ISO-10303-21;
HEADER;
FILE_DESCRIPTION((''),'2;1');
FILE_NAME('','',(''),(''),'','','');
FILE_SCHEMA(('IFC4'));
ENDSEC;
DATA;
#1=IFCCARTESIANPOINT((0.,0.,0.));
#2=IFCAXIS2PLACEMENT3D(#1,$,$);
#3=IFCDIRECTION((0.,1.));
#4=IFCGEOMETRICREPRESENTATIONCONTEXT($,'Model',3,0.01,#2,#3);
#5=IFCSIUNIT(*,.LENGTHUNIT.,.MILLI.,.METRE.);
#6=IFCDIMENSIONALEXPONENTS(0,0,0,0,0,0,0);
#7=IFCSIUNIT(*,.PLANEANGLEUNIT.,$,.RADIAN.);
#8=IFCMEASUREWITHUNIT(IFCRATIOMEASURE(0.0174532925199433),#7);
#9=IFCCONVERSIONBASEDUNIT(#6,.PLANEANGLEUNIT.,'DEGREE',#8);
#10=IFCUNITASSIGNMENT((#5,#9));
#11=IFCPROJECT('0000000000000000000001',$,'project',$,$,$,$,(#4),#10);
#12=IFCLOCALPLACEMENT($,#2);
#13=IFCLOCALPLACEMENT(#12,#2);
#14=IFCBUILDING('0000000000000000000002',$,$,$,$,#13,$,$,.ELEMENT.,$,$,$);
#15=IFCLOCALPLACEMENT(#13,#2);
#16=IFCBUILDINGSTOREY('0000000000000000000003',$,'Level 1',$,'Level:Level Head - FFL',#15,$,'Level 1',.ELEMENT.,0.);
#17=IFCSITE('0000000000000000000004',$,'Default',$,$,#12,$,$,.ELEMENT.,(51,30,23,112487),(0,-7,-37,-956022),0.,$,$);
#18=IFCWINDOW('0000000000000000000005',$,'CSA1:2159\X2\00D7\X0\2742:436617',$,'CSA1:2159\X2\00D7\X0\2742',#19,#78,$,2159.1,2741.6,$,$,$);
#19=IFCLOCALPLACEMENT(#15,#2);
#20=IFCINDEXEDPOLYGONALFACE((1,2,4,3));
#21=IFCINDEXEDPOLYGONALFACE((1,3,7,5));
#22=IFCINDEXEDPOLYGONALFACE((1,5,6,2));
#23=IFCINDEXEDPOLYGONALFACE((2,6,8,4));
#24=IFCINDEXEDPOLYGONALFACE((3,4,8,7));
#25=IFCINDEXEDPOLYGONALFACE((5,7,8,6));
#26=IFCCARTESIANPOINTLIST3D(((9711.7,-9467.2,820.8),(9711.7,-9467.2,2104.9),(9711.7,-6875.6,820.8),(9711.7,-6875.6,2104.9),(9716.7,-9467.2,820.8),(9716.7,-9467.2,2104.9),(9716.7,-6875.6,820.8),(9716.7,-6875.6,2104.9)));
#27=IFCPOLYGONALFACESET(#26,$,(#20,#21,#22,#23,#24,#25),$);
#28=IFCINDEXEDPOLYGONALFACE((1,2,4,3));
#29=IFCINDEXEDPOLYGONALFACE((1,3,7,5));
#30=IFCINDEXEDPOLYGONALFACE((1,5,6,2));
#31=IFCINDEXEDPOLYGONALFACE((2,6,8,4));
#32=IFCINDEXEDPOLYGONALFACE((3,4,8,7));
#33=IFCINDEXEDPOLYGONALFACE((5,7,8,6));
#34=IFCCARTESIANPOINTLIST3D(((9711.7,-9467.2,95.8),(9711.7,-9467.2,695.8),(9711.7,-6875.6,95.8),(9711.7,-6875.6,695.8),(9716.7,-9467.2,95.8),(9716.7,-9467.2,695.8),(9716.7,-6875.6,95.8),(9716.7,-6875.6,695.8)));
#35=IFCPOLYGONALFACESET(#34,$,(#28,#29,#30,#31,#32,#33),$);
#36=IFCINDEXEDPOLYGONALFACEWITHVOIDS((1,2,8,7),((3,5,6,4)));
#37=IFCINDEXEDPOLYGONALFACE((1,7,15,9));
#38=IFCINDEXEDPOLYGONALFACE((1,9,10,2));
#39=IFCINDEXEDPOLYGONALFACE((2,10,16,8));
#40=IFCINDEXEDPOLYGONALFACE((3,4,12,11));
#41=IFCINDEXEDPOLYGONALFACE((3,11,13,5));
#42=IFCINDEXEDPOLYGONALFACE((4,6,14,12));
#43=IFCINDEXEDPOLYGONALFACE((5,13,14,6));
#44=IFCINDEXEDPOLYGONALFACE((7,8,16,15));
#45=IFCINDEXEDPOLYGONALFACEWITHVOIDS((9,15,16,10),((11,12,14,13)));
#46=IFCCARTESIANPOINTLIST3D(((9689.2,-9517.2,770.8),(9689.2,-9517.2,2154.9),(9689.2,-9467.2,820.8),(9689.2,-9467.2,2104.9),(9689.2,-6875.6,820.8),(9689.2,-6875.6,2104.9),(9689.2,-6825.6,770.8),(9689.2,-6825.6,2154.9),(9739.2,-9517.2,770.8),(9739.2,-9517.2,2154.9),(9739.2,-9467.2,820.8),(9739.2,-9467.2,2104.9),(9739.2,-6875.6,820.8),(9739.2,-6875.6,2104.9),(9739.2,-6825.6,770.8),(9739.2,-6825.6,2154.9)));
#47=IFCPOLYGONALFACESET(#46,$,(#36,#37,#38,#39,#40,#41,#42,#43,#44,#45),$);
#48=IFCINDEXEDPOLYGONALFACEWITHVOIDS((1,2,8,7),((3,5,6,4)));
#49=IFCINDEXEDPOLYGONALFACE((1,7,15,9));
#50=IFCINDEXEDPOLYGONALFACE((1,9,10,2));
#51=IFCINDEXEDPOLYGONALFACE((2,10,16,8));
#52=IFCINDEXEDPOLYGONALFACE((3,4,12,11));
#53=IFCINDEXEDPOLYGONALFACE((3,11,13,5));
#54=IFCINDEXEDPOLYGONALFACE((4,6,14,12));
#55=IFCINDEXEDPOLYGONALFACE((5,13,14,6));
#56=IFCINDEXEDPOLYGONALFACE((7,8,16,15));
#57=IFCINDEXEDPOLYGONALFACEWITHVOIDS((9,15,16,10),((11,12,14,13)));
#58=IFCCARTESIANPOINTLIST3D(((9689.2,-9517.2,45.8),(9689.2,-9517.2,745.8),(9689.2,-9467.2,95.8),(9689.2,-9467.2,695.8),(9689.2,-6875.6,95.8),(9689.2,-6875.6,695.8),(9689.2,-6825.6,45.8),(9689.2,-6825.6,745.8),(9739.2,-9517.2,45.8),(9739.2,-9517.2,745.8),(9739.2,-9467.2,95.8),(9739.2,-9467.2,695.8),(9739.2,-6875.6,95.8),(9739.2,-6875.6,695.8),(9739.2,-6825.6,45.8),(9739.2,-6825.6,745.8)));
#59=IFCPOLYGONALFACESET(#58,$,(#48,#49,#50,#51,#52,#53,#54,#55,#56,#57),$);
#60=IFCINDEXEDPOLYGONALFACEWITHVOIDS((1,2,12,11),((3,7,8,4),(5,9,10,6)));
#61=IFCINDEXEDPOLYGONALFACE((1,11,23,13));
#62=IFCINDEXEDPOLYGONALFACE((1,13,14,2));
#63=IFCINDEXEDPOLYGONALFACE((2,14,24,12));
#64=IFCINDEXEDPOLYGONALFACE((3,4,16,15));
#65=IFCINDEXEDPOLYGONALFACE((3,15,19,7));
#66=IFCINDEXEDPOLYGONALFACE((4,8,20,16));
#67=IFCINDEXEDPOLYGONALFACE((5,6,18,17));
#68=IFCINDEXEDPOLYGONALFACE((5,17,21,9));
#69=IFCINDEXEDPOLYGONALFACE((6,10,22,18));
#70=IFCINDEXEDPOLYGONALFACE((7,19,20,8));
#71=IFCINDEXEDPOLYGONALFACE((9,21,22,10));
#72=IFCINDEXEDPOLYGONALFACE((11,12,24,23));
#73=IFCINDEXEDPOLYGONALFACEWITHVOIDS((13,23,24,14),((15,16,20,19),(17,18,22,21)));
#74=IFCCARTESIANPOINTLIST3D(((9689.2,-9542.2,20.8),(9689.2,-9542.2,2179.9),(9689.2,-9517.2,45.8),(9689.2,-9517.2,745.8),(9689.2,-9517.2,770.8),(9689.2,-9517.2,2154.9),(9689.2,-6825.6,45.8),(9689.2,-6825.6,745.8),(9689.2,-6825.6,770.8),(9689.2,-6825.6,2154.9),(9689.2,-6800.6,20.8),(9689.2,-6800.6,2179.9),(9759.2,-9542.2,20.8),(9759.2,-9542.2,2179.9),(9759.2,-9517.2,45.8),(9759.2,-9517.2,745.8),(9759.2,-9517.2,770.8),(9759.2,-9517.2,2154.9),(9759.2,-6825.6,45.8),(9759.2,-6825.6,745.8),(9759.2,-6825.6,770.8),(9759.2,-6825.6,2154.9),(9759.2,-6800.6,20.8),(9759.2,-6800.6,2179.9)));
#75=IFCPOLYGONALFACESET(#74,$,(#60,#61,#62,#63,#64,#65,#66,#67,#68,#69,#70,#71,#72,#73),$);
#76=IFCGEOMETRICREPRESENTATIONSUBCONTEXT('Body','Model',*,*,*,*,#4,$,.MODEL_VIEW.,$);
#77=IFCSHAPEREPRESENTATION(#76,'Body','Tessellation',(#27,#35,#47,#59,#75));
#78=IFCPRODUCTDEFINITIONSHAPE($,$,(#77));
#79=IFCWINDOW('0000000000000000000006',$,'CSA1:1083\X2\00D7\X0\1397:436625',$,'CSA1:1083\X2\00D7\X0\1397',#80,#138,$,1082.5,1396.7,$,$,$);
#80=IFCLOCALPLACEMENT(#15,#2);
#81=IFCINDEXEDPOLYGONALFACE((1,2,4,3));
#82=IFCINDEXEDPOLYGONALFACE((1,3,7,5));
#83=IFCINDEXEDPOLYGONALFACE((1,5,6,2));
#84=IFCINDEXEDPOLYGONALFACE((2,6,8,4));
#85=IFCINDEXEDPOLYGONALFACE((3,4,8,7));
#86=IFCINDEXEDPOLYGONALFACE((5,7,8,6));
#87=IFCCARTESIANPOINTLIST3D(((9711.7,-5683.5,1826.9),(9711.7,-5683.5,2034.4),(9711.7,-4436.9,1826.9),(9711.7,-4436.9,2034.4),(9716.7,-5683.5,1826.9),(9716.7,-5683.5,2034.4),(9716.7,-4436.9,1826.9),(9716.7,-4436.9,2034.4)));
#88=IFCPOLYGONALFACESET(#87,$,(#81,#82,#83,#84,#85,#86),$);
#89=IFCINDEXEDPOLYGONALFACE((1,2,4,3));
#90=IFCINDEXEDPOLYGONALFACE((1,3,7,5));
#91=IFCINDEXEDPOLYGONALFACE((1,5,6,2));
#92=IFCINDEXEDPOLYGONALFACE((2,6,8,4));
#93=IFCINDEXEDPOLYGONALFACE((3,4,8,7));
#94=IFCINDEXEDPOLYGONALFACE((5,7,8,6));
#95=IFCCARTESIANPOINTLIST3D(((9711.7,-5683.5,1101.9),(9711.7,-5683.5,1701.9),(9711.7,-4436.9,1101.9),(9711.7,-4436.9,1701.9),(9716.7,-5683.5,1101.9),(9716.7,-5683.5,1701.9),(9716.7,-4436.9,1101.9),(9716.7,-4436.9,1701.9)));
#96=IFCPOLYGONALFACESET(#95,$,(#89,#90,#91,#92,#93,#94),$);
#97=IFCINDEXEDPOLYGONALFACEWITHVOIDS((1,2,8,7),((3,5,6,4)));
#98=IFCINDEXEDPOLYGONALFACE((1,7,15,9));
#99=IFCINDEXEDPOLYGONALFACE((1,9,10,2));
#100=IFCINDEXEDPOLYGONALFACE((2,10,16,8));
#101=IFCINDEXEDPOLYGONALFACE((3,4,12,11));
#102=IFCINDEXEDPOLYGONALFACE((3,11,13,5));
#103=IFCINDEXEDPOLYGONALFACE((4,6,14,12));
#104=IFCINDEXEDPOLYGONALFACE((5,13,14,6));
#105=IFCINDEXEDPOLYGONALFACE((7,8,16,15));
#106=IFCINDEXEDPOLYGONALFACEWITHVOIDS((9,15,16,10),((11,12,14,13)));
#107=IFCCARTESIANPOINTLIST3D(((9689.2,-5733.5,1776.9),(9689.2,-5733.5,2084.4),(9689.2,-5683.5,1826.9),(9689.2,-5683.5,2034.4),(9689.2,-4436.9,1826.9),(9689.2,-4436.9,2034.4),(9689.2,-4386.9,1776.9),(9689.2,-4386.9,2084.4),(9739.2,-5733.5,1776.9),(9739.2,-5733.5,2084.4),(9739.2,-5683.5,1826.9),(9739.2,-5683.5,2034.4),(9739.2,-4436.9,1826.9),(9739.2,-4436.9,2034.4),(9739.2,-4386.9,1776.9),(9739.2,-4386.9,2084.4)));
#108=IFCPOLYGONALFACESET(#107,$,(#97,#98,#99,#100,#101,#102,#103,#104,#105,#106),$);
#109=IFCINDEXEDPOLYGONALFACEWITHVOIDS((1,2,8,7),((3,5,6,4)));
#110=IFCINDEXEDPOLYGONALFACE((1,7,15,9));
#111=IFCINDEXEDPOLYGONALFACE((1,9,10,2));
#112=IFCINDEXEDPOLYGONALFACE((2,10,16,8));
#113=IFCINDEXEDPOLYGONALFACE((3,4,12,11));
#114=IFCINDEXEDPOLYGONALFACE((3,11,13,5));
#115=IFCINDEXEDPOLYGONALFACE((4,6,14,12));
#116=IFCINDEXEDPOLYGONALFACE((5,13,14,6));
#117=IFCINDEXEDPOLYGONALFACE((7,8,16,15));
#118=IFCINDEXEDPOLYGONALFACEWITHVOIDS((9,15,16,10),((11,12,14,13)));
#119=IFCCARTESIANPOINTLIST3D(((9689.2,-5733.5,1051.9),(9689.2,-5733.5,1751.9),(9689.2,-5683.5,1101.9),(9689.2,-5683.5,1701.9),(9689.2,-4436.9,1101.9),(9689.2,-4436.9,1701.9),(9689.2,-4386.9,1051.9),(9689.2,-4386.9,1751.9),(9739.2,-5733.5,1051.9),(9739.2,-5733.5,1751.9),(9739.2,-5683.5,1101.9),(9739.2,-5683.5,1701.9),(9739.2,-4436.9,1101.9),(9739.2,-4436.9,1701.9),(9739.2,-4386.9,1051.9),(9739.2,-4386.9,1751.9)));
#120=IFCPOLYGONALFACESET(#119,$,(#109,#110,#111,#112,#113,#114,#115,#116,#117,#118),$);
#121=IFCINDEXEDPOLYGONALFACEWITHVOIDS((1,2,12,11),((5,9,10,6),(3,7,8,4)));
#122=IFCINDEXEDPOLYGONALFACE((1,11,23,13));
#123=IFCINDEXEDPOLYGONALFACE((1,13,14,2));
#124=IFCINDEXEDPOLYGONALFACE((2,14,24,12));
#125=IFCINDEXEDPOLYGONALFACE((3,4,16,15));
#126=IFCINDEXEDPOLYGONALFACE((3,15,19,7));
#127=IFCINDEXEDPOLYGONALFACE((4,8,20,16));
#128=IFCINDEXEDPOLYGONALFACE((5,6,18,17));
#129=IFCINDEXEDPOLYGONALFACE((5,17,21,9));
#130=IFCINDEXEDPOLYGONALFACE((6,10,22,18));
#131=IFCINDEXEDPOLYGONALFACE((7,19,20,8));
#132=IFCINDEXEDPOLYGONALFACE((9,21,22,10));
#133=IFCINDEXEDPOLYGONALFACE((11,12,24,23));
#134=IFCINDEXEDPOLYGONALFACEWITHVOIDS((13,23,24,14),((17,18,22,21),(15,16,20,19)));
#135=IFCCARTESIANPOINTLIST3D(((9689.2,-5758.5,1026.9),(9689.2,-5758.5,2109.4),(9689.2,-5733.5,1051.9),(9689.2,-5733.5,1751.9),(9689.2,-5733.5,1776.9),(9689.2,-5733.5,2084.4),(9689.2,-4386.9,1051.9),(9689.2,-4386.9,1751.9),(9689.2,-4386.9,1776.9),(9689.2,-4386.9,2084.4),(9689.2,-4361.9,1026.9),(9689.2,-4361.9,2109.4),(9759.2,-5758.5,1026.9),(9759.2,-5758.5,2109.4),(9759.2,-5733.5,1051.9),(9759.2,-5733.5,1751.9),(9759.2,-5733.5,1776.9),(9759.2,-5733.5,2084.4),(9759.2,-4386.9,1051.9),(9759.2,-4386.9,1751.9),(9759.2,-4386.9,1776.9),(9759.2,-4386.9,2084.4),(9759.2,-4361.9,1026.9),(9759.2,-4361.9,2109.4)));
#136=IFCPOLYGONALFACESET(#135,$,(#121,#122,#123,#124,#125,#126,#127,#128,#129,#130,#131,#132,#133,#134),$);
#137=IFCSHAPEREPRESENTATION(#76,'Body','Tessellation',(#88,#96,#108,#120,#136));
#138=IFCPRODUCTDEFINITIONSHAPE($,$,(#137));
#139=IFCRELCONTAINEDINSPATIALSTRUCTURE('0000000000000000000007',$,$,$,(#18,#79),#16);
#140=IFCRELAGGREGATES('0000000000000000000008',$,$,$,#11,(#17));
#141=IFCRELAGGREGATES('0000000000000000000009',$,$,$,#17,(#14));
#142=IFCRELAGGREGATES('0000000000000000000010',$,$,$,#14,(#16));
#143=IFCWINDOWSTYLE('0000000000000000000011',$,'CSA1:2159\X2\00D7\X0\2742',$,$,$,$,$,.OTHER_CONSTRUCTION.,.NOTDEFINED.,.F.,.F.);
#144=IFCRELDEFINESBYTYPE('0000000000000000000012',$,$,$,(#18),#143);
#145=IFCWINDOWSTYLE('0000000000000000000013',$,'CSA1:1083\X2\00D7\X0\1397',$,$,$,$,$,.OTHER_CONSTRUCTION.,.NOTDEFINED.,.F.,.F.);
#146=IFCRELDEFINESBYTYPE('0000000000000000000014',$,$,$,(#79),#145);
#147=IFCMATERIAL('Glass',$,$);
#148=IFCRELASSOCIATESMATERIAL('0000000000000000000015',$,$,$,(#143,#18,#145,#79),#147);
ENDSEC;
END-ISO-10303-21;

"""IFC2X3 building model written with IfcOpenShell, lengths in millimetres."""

from ifc_helpers import new_model, entity, si_unit, converted_unit, direction, frame, frame_2d, origin, origin_2d_with_axis, place, context, subcontext, project, spatial, polyline, rectangle, outline, extrude, source, transform, mapped, material, type_object, type_shapes, element, save


model = new_model("IFC2X3")

# Units and contexts
model_context = context("Model", 3, precision=0.01, world=origin(), true_north=direction((0.0, 1.0)))
body_context = subcontext(model_context, "Body", "Model", "MODEL_VIEW")
ifc_project = project(units=[si_unit("LENGTHUNIT", "METRE", prefix="MILLI"), converted_unit("PLANEANGLEUNIT", "DEGREE", entity("IfcRatioMeasure", 0.0174532925199433), si_unit("PLANEANGLEUNIT", "RADIAN"), dimensions=[0, 0, 0, 0, 0, 0, 0])], contexts=[model_context])

# Site, building, storey
site_placement = place(None, origin())
site = spatial("IfcSite", under=ifc_project, at=site_placement, Name="Default", CompositionType="ELEMENT", RefLatitude=(51, 30, 23, 112487), RefLongitude=(0, -7, -37, -956022), RefElevation=0.0)
building_placement = place(site_placement, origin())
building = spatial("IfcBuilding", under=site, at=building_placement, CompositionType="ELEMENT")
storey_placement = place(building_placement, origin())
storey = spatial("IfcBuildingStorey", under=building, at=storey_placement, Name="Level 1", ObjectType="Level:Level Head - FFL", LongName="Level 1", CompositionType="ELEMENT", Elevation=0.0)

# Windows
ifc_material_1 = material(Name="Glass")
window_style_1 = type_object("IfcWindowStyle", Name="CSA1:2159×2742", ConstructionType="OTHER_CONSTRUCTION", OperationType="NOTDEFINED", ParameterTakesPrecedence=False, Sizeable=False, material=ifc_material_1)
shared_shape_1 = source(origin(), body_context, "Body", "SweptSolid", [
    extrude(rectangle(XDim=5.0, YDim=2591.6, at=origin_2d_with_axis()), frame((1370.8, 45.0, 800.0), z_axis=(0.0, 0.0, 1.0), x_axis=(0.0, 1.0, 0.0)), (0.0, 0.0, 1.0), 1284.1),
    extrude(rectangle(XDim=5.0, YDim=2591.6, at=origin_2d_with_axis()), frame((1370.8, 45.0, 75.0), z_axis=(0.0, 0.0, 1.0), x_axis=(0.0, 1.0, 0.0)), (0.0, 0.0, 1.0), 600.0),
    extrude(outline(polyline([(-1345.8, -692.1), (1345.8, -692.1), (1345.8, 692.1), (-1345.8, 692.1), (-1345.8, -692.1)]), holes=[polyline([(-1295.8, -642.1), (-1295.8, 642.1), (1295.8, 642.1), (1295.8, -642.1), (-1295.8, -642.1)])]), frame((1370.8, 20.0, 1442.1), z_axis=(0.0, 1.0, 0.0), x_axis=(1.0, 0.0, 0.0)), (0.0, 0.0, 1.0), 50.0),
    extrude(outline(polyline([(-1345.8, -350.0), (1345.8, -350.0), (1345.8, 350.0), (-1345.8, 350.0), (-1345.8, -350.0)]), holes=[polyline([(-1295.8, -300.0), (-1295.8, 300.0), (1295.8, 300.0), (1295.8, -300.0), (-1295.8, -300.0)])]), frame((1370.8, 20.0, 375.0), z_axis=(0.0, 1.0, 0.0), x_axis=(1.0, 0.0, 0.0)), (0.0, 0.0, 1.0), 50.0),
    extrude(outline(polyline([(-1370.8, -1079.6), (1370.8, -1079.6), (1370.8, 1079.6), (-1370.8, 1079.6), (-1370.8, -1079.6)]), holes=[polyline([(-1345.8, -1054.6), (-1345.8, 329.6), (1345.8, 329.6), (1345.8, -1054.6), (-1345.8, -1054.6)]), polyline([(-1345.8, 354.6), (-1345.8, 1054.6), (1345.8, 1054.6), (1345.8, 354.6), (-1345.8, 354.6)])]), frame((1370.8, 0.0, 1079.6), z_axis=(0.0, 1.0, 0.0), x_axis=(1.0, 0.0, 0.0)), (0.0, 0.0, 1.0), 70.0),
])
type_shapes(window_style_1, [shared_shape_1])
window_1_placement = place(storey_placement, frame((9759.2, -9542.2, 20.8), z_axis=(0.0, 0.0, 1.0), x_axis=(0.0, 1.0, 0.0)))
element("IfcWindow", 1, at=window_1_placement, inside=storey, type_object=window_style_1, material=ifc_material_1, Name="CSA1:2159×2742:436617", ObjectType="CSA1:2159×2742", OverallHeight=2159.1, OverallWidth=2741.6, context=body_context, shape_type="MappedRepresentation", body=[
    mapped(shared_shape_1, transform((0.0, 0.0, 0.0), scale=1.0)),
])
window_style_2 = type_object("IfcWindowStyle", Name="CSA1:1083×1397", ConstructionType="OTHER_CONSTRUCTION", OperationType="NOTDEFINED", ParameterTakesPrecedence=False, Sizeable=False, material=ifc_material_1)
shared_shape_2 = source(origin(), body_context, "Body", "SweptSolid", [
    extrude(rectangle(XDim=5.0, YDim=1246.7, at=frame_2d((0.0, 0.0), x_axis=(1.0, 0.0))), frame((698.3, 45.0, 800.0), z_axis=(0.0, 0.0, 1.0), x_axis=(0.0, 1.0, 0.0)), (0.0, 0.0, 1.0), 207.5),
    extrude(rectangle(XDim=5.0, YDim=1246.7, at=frame_2d((0.0, 0.0), x_axis=(1.0, 0.0))), frame((698.3, 45.0, 75.0), z_axis=(0.0, 0.0, 1.0), x_axis=(0.0, 1.0, 0.0)), (0.0, 0.0, 1.0), 600.0),
    extrude(outline(polyline([(-673.3, -153.8), (673.3, -153.8), (673.3, 153.8), (-673.3, 153.8), (-673.3, -153.8)]), holes=[polyline([(-623.3, -103.8), (-623.3, 103.8), (623.3, 103.8), (623.3, -103.8), (-623.3, -103.8)])]), frame((698.3, 20.0, 903.8), z_axis=(0.0, 1.0, 0.0), x_axis=(1.0, 0.0, 0.0)), (0.0, 0.0, 1.0), 50.0),
    extrude(outline(polyline([(-673.3, -350.0), (673.3, -350.0), (673.3, 350.0), (-673.3, 350.0), (-673.3, -350.0)]), holes=[polyline([(-623.3, -300.0), (-623.3, 300.0), (623.3, 300.0), (623.3, -300.0), (-623.3, -300.0)])]), frame((698.3, 20.0, 375.0), z_axis=(0.0, 1.0, 0.0), x_axis=(1.0, 0.0, 0.0)), (0.0, 0.0, 1.0), 50.0),
    extrude(outline(polyline([(-698.3, -541.3), (698.3, -541.3), (698.3, 541.3), (-698.3, 541.3), (-698.3, -541.3)]), holes=[polyline([(-673.3, -516.3), (-673.3, -208.7), (673.3, -208.7), (673.3, -516.3), (-673.3, -516.3)]), polyline([(-673.3, -183.7), (-673.3, 516.3), (673.3, 516.3), (673.3, -183.7), (-673.3, -183.7)])]), frame((698.3, 0.0, 541.3), z_axis=(0.0, 1.0, 0.0), x_axis=(1.0, 0.0, 0.0)), (0.0, 0.0, 1.0), 70.0),
])
type_shapes(window_style_2, [shared_shape_2])
window_2_placement = place(storey_placement, frame((9759.2, -5758.5, 1026.9), z_axis=(0.0, 0.0, 1.0), x_axis=(0.0, 1.0, 0.0)))
element("IfcWindow", 2, at=window_2_placement, inside=storey, type_object=window_style_2, material=ifc_material_1, Name="CSA1:1083×1397:436625", ObjectType="CSA1:1083×1397", OverallHeight=1082.5, OverallWidth=1396.7, context=body_context, shape_type="MappedRepresentation", body=[
    mapped(shared_shape_2, transform((0.0, 0.0, 0.0), scale=1.0)),
])

save(model, "model.ifc")
